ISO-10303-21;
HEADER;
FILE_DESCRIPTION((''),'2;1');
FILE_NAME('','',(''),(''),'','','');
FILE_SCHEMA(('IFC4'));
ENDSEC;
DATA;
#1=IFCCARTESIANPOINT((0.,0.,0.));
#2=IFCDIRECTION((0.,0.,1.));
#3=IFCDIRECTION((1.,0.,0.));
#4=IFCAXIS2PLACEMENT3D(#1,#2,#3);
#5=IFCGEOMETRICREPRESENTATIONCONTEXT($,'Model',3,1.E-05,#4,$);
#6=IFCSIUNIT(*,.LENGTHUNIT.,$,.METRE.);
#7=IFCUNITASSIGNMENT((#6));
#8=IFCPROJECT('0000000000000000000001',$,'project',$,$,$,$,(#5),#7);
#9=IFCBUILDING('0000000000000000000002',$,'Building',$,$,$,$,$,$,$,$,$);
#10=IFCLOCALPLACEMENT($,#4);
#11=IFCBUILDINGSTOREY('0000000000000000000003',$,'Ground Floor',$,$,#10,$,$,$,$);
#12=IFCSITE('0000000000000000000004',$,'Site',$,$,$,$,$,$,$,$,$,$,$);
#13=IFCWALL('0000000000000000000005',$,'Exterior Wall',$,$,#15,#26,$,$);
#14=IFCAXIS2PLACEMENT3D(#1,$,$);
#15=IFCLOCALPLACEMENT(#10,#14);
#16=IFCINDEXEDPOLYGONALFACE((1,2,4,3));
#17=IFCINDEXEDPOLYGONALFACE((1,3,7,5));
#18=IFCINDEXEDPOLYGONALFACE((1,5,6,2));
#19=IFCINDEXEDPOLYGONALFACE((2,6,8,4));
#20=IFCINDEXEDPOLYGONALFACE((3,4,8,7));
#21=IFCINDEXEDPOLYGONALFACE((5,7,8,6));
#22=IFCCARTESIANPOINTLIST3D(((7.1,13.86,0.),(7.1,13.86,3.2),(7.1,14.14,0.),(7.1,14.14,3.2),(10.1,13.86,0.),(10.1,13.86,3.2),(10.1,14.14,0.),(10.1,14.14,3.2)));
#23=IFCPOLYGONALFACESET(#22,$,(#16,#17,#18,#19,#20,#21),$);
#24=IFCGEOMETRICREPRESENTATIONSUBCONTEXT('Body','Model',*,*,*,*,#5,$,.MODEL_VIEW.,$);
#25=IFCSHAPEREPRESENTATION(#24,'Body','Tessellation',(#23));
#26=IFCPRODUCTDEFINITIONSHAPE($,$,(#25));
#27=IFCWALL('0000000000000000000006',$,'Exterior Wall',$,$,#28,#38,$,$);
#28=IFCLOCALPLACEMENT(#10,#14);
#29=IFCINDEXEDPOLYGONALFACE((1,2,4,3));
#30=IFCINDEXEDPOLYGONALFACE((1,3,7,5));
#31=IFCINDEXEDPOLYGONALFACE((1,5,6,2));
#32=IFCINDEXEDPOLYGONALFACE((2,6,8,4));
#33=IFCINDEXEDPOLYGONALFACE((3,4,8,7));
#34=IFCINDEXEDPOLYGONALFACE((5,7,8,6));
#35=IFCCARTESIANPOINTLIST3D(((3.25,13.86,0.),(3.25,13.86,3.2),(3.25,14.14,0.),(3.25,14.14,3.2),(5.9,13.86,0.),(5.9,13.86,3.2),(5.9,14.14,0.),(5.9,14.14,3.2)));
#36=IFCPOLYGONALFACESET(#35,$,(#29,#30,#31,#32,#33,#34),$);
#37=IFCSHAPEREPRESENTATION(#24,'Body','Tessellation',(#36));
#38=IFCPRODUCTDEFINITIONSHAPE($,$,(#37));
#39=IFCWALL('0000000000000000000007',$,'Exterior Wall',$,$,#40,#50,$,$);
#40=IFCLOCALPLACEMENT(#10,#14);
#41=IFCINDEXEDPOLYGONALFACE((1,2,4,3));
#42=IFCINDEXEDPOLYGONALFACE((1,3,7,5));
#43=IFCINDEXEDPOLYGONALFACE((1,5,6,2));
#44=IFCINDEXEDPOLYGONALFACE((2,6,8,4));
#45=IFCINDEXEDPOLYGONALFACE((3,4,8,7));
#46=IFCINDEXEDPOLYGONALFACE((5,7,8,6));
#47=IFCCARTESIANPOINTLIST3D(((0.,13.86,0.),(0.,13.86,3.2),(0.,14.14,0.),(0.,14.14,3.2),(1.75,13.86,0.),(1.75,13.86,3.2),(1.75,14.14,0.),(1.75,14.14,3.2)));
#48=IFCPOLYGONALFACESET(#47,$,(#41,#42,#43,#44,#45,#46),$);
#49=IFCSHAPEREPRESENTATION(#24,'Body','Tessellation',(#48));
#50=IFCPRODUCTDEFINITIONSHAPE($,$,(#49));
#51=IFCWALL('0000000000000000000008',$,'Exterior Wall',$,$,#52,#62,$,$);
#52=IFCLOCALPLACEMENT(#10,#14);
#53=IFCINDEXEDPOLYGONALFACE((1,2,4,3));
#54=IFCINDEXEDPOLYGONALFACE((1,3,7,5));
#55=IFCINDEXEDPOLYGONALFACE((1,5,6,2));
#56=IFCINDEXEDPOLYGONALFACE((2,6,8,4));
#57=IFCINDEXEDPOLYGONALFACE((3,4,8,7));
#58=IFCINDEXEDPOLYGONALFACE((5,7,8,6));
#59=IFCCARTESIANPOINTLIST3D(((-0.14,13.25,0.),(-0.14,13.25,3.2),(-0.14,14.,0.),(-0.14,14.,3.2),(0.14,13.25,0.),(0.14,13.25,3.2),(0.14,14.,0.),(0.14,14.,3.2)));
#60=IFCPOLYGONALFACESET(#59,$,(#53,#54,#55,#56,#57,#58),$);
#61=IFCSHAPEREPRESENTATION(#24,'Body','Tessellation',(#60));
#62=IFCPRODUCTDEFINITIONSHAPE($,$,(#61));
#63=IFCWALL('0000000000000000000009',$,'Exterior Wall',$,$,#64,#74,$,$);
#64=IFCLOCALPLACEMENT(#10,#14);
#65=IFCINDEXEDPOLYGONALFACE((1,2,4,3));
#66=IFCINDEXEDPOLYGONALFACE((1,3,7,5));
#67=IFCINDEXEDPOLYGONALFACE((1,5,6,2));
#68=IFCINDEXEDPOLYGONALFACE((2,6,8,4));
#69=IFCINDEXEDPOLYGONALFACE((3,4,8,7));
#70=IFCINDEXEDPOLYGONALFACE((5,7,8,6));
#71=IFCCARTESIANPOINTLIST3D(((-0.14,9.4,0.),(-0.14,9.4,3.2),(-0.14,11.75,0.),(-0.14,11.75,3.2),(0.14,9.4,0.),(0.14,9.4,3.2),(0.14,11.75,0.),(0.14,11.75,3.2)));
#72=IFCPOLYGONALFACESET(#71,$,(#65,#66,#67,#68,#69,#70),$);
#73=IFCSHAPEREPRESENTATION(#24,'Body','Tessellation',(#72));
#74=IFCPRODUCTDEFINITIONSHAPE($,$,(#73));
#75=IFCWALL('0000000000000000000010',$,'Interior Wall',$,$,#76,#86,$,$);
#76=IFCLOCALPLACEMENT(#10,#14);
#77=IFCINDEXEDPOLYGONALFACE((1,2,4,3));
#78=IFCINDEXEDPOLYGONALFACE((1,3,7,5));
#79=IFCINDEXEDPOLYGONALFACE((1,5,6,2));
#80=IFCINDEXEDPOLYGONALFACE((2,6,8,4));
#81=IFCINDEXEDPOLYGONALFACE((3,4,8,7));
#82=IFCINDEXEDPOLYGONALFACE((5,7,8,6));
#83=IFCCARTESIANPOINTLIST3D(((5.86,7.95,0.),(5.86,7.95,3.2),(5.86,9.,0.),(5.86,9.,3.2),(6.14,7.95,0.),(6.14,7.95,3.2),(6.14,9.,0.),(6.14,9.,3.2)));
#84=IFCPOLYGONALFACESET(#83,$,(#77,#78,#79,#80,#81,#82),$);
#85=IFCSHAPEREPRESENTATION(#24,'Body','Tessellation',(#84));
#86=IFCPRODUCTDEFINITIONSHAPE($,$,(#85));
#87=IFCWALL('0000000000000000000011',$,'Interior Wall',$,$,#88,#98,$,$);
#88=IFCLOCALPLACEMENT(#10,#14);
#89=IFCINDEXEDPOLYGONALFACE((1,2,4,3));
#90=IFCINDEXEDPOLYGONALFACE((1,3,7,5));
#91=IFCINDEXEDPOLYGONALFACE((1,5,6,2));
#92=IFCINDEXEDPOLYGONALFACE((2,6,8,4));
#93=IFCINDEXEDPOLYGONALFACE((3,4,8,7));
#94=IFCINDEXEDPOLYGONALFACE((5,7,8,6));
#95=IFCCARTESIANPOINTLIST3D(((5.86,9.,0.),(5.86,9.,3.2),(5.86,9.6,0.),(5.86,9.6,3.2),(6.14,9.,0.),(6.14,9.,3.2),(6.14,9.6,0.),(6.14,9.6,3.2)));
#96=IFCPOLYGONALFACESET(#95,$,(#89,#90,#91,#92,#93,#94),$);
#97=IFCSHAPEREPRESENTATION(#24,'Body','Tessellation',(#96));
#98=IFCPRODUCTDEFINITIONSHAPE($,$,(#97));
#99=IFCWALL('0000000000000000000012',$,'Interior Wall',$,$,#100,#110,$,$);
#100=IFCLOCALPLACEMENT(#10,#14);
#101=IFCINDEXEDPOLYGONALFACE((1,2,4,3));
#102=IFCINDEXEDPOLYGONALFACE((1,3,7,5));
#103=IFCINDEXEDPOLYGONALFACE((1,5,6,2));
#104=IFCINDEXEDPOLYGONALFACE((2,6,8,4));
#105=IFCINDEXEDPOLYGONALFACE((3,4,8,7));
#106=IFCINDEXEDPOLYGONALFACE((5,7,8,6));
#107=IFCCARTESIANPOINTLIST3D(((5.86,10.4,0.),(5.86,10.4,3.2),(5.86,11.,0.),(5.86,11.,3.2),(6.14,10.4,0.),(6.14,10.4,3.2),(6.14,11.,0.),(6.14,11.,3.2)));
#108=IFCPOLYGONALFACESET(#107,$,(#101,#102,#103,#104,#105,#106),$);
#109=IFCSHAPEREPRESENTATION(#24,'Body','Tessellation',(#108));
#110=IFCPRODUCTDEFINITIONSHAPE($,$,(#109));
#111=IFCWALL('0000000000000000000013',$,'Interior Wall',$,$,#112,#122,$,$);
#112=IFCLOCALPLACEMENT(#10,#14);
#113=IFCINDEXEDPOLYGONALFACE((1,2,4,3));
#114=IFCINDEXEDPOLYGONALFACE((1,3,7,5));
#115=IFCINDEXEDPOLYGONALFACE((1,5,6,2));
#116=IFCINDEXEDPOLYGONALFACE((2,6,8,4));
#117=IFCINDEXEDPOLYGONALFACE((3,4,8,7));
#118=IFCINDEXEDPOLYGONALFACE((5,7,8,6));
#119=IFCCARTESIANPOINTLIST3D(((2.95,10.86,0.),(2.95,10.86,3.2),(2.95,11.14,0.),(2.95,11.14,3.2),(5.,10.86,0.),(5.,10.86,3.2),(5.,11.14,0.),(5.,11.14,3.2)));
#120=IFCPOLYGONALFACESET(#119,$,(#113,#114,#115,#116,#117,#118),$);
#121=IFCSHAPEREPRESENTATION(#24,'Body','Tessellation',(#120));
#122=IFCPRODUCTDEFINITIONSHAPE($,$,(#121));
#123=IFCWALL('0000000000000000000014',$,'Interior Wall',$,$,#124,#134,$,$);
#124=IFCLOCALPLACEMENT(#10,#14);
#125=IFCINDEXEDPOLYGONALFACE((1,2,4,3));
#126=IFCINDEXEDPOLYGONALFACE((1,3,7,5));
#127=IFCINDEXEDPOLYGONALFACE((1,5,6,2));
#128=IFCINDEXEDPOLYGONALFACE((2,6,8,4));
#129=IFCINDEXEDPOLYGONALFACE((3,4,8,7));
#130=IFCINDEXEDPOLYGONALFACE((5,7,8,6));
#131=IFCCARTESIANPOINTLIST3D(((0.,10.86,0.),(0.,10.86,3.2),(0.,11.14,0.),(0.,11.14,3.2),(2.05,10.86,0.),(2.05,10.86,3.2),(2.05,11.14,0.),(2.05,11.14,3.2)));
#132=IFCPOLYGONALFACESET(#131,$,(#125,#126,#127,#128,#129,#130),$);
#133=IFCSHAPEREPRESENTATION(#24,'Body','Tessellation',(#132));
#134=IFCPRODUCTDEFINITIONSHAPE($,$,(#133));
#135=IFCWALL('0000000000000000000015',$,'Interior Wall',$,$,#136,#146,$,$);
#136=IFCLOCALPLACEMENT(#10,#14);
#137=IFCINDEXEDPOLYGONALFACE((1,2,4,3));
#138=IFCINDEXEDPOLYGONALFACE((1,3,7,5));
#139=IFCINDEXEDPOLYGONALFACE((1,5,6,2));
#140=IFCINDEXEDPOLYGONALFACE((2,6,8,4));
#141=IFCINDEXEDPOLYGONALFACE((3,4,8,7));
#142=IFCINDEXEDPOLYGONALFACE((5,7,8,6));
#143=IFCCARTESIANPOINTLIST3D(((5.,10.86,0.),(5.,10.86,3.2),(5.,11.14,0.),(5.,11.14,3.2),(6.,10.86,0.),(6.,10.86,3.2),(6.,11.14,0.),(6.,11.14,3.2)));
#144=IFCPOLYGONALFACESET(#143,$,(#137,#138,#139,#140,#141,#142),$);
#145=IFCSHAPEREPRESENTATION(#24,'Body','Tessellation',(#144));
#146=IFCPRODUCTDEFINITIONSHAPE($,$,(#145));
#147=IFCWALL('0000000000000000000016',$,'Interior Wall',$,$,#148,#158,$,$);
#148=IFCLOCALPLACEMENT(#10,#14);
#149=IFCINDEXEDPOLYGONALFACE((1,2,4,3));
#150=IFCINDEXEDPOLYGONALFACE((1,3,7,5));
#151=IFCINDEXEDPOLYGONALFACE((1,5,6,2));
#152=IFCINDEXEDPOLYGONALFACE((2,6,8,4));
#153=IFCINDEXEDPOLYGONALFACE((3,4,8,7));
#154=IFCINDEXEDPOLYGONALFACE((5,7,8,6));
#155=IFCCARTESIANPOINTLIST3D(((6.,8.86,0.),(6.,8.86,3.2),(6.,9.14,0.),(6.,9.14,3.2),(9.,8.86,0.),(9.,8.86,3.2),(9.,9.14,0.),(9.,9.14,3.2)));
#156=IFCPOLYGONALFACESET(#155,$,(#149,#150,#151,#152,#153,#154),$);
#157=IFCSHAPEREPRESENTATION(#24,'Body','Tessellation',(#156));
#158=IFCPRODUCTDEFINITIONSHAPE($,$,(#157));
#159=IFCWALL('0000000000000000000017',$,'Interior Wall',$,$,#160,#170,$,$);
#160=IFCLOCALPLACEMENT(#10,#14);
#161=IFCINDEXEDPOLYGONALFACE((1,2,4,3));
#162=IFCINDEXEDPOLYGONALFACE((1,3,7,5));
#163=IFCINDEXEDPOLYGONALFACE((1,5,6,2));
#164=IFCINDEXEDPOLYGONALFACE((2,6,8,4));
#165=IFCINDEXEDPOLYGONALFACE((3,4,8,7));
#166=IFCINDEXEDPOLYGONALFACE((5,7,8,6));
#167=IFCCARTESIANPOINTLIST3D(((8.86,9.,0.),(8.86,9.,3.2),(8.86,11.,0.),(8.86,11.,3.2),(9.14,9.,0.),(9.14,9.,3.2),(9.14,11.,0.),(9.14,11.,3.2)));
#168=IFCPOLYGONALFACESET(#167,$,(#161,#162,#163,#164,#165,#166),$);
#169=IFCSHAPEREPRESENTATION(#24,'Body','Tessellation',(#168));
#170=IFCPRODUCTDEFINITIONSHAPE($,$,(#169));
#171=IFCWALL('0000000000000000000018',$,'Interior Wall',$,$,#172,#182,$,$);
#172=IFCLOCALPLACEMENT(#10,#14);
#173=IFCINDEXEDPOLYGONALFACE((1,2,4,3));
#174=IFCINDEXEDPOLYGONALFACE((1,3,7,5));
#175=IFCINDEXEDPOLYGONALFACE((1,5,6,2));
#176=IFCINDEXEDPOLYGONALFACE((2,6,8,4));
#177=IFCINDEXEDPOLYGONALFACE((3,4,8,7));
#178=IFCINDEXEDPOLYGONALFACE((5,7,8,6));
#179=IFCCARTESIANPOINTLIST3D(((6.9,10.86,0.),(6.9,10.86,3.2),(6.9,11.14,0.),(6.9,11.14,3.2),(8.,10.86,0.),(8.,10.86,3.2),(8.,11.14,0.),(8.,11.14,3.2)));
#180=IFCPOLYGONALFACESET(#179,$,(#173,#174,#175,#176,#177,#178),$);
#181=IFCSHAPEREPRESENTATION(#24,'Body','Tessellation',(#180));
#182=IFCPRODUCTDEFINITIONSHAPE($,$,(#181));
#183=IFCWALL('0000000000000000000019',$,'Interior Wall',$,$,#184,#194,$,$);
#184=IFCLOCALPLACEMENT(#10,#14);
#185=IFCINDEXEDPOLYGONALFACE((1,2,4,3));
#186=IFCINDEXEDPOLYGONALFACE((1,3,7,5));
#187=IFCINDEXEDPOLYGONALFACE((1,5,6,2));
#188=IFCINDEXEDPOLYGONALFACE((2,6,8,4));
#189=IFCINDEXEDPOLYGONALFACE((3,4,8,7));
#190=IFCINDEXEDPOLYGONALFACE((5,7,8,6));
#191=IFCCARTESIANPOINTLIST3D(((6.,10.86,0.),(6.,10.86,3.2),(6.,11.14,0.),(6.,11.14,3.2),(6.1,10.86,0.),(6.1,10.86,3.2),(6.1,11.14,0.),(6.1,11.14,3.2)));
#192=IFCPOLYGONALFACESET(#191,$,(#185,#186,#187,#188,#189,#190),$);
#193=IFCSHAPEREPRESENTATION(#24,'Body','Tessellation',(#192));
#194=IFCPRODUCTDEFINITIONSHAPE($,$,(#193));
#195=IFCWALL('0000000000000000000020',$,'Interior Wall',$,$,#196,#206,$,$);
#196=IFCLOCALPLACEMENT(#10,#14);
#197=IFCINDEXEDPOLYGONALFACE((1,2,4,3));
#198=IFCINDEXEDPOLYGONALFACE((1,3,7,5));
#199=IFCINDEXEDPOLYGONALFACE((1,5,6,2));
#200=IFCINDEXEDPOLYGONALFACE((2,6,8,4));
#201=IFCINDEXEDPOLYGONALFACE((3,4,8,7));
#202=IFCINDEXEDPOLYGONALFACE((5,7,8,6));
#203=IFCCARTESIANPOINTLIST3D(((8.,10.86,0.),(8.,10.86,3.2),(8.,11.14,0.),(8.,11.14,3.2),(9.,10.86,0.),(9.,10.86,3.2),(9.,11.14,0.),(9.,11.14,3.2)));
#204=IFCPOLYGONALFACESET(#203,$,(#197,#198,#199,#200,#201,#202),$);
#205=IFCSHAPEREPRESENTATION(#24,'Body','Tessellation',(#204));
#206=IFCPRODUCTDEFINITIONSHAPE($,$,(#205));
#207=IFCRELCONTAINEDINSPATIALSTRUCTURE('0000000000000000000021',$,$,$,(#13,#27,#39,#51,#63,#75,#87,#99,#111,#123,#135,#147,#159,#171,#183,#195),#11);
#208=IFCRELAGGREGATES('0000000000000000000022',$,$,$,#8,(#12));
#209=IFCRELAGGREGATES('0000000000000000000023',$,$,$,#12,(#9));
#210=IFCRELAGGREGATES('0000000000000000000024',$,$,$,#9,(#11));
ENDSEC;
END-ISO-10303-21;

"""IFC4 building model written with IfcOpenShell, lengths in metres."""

from ifc_helpers import new_model, si_unit, frame, origin_with_axes, place, context, subcontext, project, spatial, indexed_curve, outline, extrude, element, save


model = new_model("IFC4")

# Units and contexts
model_context = context("Model", 3, precision=1e-05, world=origin_with_axes())
body_context = subcontext(model_context, "Body", "Model", "MODEL_VIEW")
ifc_project = project(units=[si_unit("LENGTHUNIT", "METRE")], contexts=[model_context])

# Site, building, storey
site = spatial("IfcSite", under=ifc_project, Name="Site")
building = spatial("IfcBuilding", under=site, Name="Building")
storey_placement = place(None, origin_with_axes())
storey = spatial("IfcBuildingStorey", under=building, at=storey_placement, Name="Ground Floor")

# Walls
wall_1_placement = place(storey_placement, frame((10.1, 14.0, 0.0), z_axis=(0.0, 0.0, 1.0), x_axis=(-1.0, 0.0, 0.0)))
element("IfcWall", 1, at=wall_1_placement, inside=storey, Name="Exterior Wall", context=body_context, shape_type="SweptSolid", body=[
    extrude(outline(indexed_curve([(0.0, 0.0), (0.0, 0.28), (3.0, 0.28), (3.0, 0.0), (0.0, 0.0)], self_intersect=False)), frame((0.0, -0.14, 0.0), z_axis=(0.0, 0.0, 1.0), x_axis=(1.0, 0.0, 0.0)), (0.0, 0.0, 1.0), 3.2),
])
wall_2_placement = place(storey_placement, frame((5.9, 14.0, 0.0), z_axis=(0.0, 0.0, 1.0), x_axis=(-1.0, 0.0, 0.0)))
element("IfcWall", 2, at=wall_2_placement, inside=storey, Name="Exterior Wall", context=body_context, shape_type="SweptSolid", body=[
    extrude(outline(indexed_curve([(0.0, 0.0), (0.0, 0.28), (2.65, 0.28), (2.65, 0.0), (0.0, 0.0)], self_intersect=False)), frame((0.0, -0.14, 0.0), z_axis=(0.0, 0.0, 1.0), x_axis=(1.0, 0.0, 0.0)), (0.0, 0.0, 1.0), 3.2),
])
wall_3_placement = place(storey_placement, frame((1.75, 14.0, 0.0), z_axis=(0.0, 0.0, 1.0), x_axis=(-1.0, 0.0, 0.0)))
element("IfcWall", 3, at=wall_3_placement, inside=storey, Name="Exterior Wall", context=body_context, shape_type="SweptSolid", body=[
    extrude(outline(indexed_curve([(0.0, 0.0), (0.0, 0.28), (1.75, 0.28), (1.75, 0.0), (0.0, 0.0)], self_intersect=False)), frame((0.0, -0.14, 0.0), z_axis=(0.0, 0.0, 1.0), x_axis=(1.0, 0.0, 0.0)), (0.0, 0.0, 1.0), 3.2),
])
wall_4_placement = place(storey_placement, frame((0.0, 14.0, 0.0), z_axis=(0.0, 0.0, 1.0), x_axis=(0.0, -1.0, 0.0)))
element("IfcWall", 4, at=wall_4_placement, inside=storey, Name="Exterior Wall", context=body_context, shape_type="SweptSolid", body=[
    extrude(outline(indexed_curve([(0.0, 0.0), (0.0, 0.28), (0.75, 0.28), (0.75, 0.0), (0.0, 0.0)], self_intersect=False)), frame((0.0, -0.14, 0.0), z_axis=(0.0, 0.0, 1.0), x_axis=(1.0, 0.0, 0.0)), (0.0, 0.0, 1.0), 3.2),
])
wall_5_placement = place(storey_placement, frame((0.0, 11.75, 0.0), z_axis=(0.0, 0.0, 1.0), x_axis=(0.0, -1.0, 0.0)))
element("IfcWall", 5, at=wall_5_placement, inside=storey, Name="Exterior Wall", context=body_context, shape_type="SweptSolid", body=[
    extrude(outline(indexed_curve([(0.0, 0.0), (0.0, 0.28), (2.35, 0.28), (2.35, 0.0), (0.0, 0.0)], self_intersect=False)), frame((0.0, -0.14, 0.0), z_axis=(0.0, 0.0, 1.0), x_axis=(1.0, 0.0, 0.0)), (0.0, 0.0, 1.0), 3.2),
])
wall_6_placement = place(storey_placement, frame((6.0, 7.95, 0.0), z_axis=(0.0, 0.0, 1.0), x_axis=(0.0, 1.0, 0.0)))
element("IfcWall", 6, at=wall_6_placement, inside=storey, Name="Interior Wall", context=body_context, shape_type="SweptSolid", body=[
    extrude(outline(indexed_curve([(0.0, 0.0), (0.0, 0.28), (1.05, 0.28), (1.05, 0.0), (0.0, 0.0)], self_intersect=False)), frame((0.0, -0.14, 0.0), z_axis=(0.0, 0.0, 1.0), x_axis=(1.0, 0.0, 0.0)), (0.0, 0.0, 1.0), 3.2),
])
for number, where, z_axis, x_axis, name in (
    (7, (6.0, 9.0, 0.0), (0.0, 0.0, 1.0), (0.0, 1.0, 0.0), "Interior Wall"),
    (8, (6.0, 10.4, 0.0), (0.0, 0.0, 1.0), (0.0, 1.0, 0.0), "Interior Wall"),
):
    element("IfcWall", number, at=place(storey_placement, frame(where, z_axis=z_axis, x_axis=x_axis)), inside=storey, Name=name, context=body_context, shape_type="SweptSolid", body=[
        extrude(outline(indexed_curve([(0.0, 0.0), (0.0, 0.28), (0.6, 0.28), (0.6, 0.0), (0.0, 0.0)], self_intersect=False)), frame((0.0, -0.14, 0.0), z_axis=(0.0, 0.0, 1.0), x_axis=(1.0, 0.0, 0.0)), (0.0, 0.0, 1.0), 3.2),
    ])
for number, where, z_axis, x_axis, name in (
    (9, (5.0, 11.0, 0.0), (0.0, 0.0, 1.0), (-1.0, 0.0, 0.0), "Interior Wall"),
    (10, (2.05, 11.0, 0.0), (0.0, 0.0, 1.0), (-1.0, 0.0, 0.0), "Interior Wall"),
):
    element("IfcWall", number, at=place(storey_placement, frame(where, z_axis=z_axis, x_axis=x_axis)), inside=storey, Name=name, context=body_context, shape_type="SweptSolid", body=[
        extrude(outline(indexed_curve([(0.0, 0.0), (0.0, 0.28), (2.05, 0.28), (2.05, 0.0), (0.0, 0.0)], self_intersect=False)), frame((0.0, -0.14, 0.0), z_axis=(0.0, 0.0, 1.0), x_axis=(1.0, 0.0, 0.0)), (0.0, 0.0, 1.0), 3.2),
    ])
wall_7_placement = place(storey_placement, frame((6.0, 11.0, 0.0), z_axis=(0.0, 0.0, 1.0), x_axis=(-1.0, 0.0, 0.0)))
element("IfcWall", 11, at=wall_7_placement, inside=storey, Name="Interior Wall", context=body_context, shape_type="SweptSolid", body=[
    extrude(outline(indexed_curve([(0.0, 0.0), (0.0, 0.28), (1.0, 0.28), (1.0, 0.0), (0.0, 0.0)], self_intersect=False)), frame((0.0, -0.14, 0.0), z_axis=(0.0, 0.0, 1.0), x_axis=(1.0, 0.0, 0.0)), (0.0, 0.0, 1.0), 3.2),
])
wall_8_placement = place(storey_placement, frame((9.0, 9.0, 0.0), z_axis=(0.0, 0.0, 1.0), x_axis=(-1.0, 0.0, 0.0)))
element("IfcWall", 12, at=wall_8_placement, inside=storey, Name="Interior Wall", context=body_context, shape_type="SweptSolid", body=[
    extrude(outline(indexed_curve([(0.0, 0.0), (0.0, 0.28), (3.0, 0.28), (3.0, 0.0), (0.0, 0.0)], self_intersect=False)), frame((0.0, -0.14, 0.0), z_axis=(0.0, 0.0, 1.0), x_axis=(1.0, 0.0, 0.0)), (0.0, 0.0, 1.0), 3.2),
])
wall_9_placement = place(storey_placement, frame((9.0, 9.0, 0.0), z_axis=(0.0, 0.0, 1.0), x_axis=(0.0, 1.0, 0.0)))
element("IfcWall", 13, at=wall_9_placement, inside=storey, Name="Interior Wall", context=body_context, shape_type="SweptSolid", body=[
    extrude(outline(indexed_curve([(0.0, 0.0), (0.0, 0.28), (2.0, 0.28), (2.0, 0.0), (0.0, 0.0)], self_intersect=False)), frame((0.0, -0.14, 0.0), z_axis=(0.0, 0.0, 1.0), x_axis=(1.0, 0.0, 0.0)), (0.0, 0.0, 1.0), 3.2),
])
wall_10_placement = place(storey_placement, frame((8.0, 11.0, 0.0), z_axis=(0.0, 0.0, 1.0), x_axis=(-1.0, 0.0, 0.0)))
element("IfcWall", 14, at=wall_10_placement, inside=storey, Name="Interior Wall", context=body_context, shape_type="SweptSolid", body=[
    extrude(outline(indexed_curve([(0.0, 0.0), (0.0, 0.28), (1.1, 0.28), (1.1, 0.0), (0.0, 0.0)], self_intersect=False)), frame((0.0, -0.14, 0.0), z_axis=(0.0, 0.0, 1.0), x_axis=(1.0, 0.0, 0.0)), (0.0, 0.0, 1.0), 3.2),
])
wall_11_placement = place(storey_placement, frame((6.1, 11.0, 0.0), z_axis=(0.0, 0.0, 1.0), x_axis=(-1.0, 0.0, 0.0)))
element("IfcWall", 15, at=wall_11_placement, inside=storey, Name="Interior Wall", context=body_context, shape_type="SweptSolid", body=[
    extrude(outline(indexed_curve([(0.0, 0.0), (0.0, 0.28), (0.1, 0.28), (0.1, 0.0), (0.0, 0.0)], self_intersect=False)), frame((0.0, -0.14, 0.0), z_axis=(0.0, 0.0, 1.0), x_axis=(1.0, 0.0, 0.0)), (0.0, 0.0, 1.0), 3.2),
])
wall_12_placement = place(storey_placement, frame((9.0, 11.0, 0.0), z_axis=(0.0, 0.0, 1.0), x_axis=(-1.0, 0.0, 0.0)))
element("IfcWall", 16, at=wall_12_placement, inside=storey, Name="Interior Wall", context=body_context, shape_type="SweptSolid", body=[
    extrude(outline(indexed_curve([(0.0, 0.0), (0.0, 0.28), (1.0, 0.28), (1.0, 0.0), (0.0, 0.0)], self_intersect=False)), frame((0.0, -0.14, 0.0), z_axis=(0.0, 0.0, 1.0), x_axis=(1.0, 0.0, 0.0)), (0.0, 0.0, 1.0), 3.2),
])

save(model, "model.ifc")
